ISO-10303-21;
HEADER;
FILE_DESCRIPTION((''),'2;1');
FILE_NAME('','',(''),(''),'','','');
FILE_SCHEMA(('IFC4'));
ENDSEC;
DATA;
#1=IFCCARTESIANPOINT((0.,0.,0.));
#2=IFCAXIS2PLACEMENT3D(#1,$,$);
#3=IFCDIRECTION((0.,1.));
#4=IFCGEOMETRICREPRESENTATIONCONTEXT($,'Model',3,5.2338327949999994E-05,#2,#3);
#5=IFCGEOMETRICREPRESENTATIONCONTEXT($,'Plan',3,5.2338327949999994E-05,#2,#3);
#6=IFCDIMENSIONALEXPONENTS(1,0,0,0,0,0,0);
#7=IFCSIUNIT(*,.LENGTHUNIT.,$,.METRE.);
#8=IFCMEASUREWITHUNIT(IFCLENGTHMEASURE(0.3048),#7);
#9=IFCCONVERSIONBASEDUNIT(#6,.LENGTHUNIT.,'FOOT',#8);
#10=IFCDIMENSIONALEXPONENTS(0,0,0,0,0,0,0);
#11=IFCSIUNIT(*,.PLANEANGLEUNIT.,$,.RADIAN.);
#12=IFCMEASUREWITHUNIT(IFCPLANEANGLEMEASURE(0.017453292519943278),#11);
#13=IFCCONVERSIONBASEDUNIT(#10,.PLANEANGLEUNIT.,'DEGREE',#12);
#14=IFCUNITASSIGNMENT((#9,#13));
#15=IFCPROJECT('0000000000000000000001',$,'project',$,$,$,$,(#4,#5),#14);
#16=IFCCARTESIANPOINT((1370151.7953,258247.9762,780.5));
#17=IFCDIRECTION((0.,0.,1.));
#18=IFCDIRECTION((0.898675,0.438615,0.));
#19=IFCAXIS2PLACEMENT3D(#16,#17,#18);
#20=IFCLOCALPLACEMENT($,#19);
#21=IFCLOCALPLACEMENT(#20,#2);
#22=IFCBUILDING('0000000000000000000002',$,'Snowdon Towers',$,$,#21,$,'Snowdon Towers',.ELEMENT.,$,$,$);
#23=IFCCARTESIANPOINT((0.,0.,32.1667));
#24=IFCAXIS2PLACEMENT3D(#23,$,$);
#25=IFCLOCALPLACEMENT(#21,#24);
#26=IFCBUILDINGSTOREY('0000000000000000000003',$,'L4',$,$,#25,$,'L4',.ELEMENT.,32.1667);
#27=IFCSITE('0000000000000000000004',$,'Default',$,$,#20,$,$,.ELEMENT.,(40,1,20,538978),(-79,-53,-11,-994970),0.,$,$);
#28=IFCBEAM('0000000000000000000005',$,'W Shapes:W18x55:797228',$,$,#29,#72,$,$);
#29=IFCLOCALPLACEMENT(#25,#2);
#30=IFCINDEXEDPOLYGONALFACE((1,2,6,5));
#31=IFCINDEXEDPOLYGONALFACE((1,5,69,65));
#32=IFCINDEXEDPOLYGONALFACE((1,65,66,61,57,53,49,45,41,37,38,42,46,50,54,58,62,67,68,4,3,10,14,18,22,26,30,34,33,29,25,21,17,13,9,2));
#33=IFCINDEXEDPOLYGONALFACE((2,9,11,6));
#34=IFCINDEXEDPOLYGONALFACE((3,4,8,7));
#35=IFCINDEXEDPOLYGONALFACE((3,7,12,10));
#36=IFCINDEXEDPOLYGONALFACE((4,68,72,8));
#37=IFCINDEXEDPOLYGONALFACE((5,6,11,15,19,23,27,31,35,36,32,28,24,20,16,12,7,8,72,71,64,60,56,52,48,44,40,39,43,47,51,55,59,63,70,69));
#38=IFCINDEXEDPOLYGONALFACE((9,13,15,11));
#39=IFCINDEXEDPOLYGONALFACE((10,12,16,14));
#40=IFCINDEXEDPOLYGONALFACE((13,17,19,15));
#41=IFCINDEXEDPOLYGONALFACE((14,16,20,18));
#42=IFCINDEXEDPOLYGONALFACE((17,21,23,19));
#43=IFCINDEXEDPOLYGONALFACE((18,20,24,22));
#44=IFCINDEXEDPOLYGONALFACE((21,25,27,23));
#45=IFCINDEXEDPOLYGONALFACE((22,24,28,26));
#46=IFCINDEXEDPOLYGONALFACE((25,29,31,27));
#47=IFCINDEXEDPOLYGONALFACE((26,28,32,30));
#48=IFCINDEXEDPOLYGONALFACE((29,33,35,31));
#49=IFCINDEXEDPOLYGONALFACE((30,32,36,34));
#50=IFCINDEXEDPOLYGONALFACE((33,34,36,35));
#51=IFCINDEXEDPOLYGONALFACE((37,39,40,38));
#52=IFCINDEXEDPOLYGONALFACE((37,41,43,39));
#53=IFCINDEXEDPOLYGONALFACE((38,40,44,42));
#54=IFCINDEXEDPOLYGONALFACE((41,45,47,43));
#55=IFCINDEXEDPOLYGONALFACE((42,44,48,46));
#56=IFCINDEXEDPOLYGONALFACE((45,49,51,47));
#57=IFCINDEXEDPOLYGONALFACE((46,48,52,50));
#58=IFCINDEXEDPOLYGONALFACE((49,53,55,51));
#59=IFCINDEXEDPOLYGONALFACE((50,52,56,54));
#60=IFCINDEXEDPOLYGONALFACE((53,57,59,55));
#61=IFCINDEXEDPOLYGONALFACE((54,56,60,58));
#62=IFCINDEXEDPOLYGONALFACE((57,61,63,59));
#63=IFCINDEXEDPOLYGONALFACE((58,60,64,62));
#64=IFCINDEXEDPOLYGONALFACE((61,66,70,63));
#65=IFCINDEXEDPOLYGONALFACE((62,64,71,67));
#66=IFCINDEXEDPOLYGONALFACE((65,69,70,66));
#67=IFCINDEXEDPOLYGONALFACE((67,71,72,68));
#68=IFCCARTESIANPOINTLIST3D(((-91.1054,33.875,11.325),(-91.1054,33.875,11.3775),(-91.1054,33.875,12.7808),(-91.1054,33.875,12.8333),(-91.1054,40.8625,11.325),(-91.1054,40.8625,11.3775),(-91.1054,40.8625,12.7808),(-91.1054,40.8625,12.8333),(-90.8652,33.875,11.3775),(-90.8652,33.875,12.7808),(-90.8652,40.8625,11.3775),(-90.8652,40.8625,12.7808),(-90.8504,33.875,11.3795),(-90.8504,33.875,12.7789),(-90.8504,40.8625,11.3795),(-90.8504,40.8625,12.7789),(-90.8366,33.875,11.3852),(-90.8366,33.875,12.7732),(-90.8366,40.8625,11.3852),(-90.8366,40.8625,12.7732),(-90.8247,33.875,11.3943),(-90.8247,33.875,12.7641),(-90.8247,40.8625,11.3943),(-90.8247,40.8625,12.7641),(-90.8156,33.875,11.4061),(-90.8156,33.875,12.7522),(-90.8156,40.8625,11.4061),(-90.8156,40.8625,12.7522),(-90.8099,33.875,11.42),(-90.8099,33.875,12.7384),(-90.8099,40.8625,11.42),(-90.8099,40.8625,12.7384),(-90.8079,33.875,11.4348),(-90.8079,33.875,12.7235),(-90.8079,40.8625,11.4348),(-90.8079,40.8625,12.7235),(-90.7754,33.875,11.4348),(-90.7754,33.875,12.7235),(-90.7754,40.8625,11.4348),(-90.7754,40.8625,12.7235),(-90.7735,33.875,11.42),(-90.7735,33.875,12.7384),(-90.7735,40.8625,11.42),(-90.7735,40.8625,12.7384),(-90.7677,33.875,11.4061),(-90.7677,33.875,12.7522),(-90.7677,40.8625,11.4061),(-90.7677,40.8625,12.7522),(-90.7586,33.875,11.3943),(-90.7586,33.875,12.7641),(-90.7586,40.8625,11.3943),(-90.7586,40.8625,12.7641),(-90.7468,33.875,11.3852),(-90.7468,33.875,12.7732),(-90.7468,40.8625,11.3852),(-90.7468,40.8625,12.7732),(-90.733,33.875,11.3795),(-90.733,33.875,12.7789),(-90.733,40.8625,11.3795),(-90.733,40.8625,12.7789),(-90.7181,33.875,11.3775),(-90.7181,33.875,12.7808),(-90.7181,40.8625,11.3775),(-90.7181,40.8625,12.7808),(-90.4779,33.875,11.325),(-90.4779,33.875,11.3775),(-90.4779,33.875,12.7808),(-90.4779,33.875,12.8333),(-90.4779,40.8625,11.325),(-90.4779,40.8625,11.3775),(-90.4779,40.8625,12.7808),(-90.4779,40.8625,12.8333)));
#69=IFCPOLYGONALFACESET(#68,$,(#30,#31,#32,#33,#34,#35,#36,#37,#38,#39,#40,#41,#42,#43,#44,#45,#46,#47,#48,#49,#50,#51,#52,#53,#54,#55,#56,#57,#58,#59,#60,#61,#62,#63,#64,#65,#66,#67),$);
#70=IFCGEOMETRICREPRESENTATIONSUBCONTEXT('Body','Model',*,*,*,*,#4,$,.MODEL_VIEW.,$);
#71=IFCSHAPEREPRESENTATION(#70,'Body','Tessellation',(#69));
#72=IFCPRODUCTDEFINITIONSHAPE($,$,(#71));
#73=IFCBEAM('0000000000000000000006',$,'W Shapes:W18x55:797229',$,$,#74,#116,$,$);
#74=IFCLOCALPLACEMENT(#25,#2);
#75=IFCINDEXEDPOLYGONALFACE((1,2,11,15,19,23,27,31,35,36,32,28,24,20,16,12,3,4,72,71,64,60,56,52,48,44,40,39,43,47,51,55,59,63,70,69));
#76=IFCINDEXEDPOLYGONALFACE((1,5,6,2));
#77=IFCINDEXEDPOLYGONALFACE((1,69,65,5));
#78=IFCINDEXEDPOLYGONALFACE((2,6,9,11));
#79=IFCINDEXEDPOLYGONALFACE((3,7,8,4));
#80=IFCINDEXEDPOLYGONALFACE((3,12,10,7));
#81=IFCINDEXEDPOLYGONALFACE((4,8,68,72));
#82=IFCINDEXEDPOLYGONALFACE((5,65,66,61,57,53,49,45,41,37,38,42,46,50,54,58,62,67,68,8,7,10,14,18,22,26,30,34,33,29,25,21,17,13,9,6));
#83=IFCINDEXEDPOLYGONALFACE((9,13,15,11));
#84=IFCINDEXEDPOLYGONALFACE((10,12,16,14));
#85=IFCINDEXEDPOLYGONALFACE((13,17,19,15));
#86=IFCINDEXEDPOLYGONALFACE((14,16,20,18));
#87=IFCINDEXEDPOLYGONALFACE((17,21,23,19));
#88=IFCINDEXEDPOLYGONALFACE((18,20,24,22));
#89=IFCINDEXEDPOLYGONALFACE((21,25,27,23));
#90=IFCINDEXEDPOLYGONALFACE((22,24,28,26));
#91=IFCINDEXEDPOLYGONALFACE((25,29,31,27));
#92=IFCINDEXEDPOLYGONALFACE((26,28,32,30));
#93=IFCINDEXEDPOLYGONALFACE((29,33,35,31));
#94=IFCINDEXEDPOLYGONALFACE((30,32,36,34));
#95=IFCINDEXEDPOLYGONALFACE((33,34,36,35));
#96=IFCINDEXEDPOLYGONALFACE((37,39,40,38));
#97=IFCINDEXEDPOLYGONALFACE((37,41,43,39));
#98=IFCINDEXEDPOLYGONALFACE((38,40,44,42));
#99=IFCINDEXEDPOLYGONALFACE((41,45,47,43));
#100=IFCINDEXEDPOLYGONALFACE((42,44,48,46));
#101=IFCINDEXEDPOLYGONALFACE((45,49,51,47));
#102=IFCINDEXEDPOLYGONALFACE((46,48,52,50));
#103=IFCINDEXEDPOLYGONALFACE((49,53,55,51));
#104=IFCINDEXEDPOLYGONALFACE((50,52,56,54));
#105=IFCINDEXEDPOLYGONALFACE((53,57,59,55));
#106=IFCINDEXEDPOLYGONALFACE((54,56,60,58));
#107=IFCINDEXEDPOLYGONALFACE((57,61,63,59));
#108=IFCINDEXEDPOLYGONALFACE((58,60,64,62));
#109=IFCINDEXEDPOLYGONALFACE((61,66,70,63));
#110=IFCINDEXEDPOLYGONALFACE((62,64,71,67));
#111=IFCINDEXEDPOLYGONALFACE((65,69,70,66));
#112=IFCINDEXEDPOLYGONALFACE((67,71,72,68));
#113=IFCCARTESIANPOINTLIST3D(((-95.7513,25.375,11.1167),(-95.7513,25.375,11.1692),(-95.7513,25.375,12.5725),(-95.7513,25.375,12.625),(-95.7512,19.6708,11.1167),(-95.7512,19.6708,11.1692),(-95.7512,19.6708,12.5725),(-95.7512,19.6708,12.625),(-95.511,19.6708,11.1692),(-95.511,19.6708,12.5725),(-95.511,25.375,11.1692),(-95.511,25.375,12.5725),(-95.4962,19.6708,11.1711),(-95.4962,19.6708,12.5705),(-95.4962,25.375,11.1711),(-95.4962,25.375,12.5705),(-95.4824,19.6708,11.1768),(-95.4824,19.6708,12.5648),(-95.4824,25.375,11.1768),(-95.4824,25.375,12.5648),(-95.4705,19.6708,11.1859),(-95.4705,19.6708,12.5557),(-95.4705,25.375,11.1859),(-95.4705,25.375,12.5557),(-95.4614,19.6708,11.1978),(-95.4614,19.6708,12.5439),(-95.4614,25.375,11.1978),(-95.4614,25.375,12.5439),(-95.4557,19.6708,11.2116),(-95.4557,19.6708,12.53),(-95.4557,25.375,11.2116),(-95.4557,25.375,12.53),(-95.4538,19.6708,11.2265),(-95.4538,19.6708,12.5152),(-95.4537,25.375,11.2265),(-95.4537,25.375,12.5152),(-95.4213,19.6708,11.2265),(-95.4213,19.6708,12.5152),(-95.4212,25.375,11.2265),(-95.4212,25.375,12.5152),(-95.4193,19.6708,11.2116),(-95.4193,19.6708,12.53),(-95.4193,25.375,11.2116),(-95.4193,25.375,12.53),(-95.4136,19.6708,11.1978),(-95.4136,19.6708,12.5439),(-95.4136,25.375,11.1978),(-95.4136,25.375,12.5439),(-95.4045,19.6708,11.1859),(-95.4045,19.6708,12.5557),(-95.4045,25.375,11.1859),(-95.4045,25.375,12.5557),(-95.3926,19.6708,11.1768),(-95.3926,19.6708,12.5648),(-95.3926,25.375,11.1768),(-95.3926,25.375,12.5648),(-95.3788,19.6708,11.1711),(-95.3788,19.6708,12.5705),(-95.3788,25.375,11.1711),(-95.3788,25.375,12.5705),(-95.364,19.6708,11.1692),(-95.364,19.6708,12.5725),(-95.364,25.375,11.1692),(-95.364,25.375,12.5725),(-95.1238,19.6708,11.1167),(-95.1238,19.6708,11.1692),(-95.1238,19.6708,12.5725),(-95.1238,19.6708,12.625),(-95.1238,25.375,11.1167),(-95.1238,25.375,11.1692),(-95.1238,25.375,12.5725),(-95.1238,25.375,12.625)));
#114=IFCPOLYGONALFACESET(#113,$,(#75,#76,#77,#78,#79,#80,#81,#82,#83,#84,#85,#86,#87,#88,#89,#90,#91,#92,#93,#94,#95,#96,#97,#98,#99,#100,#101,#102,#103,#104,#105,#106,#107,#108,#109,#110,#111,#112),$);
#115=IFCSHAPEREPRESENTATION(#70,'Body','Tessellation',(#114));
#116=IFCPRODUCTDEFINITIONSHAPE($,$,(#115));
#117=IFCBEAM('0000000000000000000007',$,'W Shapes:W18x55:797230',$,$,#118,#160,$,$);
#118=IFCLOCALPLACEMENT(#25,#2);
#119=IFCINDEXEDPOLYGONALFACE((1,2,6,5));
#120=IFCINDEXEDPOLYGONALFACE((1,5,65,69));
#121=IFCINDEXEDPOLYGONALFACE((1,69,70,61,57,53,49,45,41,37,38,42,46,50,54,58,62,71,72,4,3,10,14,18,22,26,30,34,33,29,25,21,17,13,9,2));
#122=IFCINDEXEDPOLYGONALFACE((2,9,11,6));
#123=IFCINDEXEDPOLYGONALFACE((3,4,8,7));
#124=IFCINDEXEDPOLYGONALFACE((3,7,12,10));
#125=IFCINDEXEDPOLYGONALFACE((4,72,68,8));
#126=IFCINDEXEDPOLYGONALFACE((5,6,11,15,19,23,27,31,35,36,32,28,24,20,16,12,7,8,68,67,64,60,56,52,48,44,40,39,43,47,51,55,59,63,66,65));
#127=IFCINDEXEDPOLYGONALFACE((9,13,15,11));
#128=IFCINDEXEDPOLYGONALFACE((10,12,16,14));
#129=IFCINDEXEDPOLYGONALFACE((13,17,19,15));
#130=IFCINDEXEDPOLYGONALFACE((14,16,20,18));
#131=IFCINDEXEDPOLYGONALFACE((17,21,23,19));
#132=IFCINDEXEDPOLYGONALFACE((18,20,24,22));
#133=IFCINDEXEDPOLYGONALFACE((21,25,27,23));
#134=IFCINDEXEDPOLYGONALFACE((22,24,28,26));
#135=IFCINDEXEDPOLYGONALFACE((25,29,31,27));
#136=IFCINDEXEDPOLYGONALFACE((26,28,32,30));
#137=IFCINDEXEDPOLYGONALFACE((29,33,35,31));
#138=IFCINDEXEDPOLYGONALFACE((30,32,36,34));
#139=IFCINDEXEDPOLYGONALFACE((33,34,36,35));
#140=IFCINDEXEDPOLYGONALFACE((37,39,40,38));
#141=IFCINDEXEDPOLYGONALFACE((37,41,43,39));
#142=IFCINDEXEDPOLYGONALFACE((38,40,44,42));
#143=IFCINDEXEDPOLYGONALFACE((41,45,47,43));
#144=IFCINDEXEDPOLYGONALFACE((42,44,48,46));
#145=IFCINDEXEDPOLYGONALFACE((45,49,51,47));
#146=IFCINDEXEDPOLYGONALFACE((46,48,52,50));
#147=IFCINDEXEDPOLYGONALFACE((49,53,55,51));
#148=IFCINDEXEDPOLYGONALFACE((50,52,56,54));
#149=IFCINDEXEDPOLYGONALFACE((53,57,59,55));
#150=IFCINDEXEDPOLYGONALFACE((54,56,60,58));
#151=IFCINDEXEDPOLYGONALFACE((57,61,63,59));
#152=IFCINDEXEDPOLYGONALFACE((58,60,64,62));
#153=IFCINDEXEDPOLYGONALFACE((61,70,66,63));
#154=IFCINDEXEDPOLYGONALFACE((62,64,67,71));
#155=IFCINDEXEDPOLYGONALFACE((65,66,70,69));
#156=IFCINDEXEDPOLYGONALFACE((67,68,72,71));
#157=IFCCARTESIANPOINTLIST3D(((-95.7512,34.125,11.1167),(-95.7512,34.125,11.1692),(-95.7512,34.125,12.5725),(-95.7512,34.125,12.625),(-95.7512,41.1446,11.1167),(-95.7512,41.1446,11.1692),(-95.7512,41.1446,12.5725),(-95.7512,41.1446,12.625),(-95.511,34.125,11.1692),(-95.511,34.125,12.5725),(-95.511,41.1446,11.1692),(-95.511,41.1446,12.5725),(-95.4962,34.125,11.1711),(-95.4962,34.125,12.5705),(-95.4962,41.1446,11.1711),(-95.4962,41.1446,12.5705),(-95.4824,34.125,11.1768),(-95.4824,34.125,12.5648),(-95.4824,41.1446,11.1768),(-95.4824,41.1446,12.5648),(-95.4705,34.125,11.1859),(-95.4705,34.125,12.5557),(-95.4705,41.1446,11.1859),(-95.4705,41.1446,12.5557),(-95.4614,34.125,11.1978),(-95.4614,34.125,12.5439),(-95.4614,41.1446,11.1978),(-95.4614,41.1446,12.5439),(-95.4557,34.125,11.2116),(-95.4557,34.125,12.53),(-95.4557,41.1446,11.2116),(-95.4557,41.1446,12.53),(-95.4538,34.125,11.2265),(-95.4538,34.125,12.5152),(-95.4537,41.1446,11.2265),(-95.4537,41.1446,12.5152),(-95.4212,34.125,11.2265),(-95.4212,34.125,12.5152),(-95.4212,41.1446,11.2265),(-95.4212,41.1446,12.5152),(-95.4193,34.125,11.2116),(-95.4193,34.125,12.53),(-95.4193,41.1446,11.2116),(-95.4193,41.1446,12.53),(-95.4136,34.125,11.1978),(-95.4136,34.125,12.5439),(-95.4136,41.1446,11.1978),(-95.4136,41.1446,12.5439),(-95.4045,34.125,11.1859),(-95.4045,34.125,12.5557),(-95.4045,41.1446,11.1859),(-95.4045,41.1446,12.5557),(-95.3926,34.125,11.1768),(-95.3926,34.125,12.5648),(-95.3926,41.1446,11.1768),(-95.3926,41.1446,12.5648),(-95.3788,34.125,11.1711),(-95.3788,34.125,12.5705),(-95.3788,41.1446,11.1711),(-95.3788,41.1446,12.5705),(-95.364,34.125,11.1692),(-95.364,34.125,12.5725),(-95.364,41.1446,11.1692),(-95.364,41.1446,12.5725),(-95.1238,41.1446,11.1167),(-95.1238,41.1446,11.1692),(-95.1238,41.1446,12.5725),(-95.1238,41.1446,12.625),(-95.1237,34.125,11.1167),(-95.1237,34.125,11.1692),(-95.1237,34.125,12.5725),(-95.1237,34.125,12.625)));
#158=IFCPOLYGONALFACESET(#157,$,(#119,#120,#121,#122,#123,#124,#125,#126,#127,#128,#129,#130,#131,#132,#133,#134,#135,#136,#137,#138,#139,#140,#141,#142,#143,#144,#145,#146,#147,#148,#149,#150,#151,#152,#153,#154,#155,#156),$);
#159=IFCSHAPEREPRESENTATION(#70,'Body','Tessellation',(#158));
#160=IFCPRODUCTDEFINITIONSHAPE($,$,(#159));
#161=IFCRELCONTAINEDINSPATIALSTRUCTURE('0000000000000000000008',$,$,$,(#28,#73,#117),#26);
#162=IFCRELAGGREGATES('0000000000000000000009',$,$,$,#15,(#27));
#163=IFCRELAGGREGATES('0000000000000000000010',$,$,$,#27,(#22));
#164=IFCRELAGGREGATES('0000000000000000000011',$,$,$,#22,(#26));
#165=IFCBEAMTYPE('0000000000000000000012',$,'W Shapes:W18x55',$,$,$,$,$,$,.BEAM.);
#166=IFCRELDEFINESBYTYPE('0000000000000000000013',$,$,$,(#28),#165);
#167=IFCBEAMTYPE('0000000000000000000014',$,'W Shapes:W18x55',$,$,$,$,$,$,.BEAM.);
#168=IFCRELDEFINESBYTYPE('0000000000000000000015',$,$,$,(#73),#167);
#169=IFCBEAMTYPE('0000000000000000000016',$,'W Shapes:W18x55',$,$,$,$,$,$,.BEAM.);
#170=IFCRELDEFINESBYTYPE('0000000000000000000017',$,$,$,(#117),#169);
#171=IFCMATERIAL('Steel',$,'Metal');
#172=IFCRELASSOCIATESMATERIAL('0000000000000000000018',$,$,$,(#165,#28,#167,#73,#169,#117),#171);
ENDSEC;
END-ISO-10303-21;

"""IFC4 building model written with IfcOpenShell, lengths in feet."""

from ifc_helpers import new_model, entity, si_unit, converted_unit, direction, frame, origin, place, context, subcontext, project, spatial, line, arc, indexed_curve, outline, extrude, source, transform, mapped, material, type_object, type_shapes, element, save


model = new_model("IFC4")

# Units and contexts
model_context = context("Model", 3, precision=5.2338327949999994e-05, world=origin(), true_north=direction((0.0, 1.0)))
plan_context = context("Plan", 3, precision=5.2338327949999994e-05, world=origin(), true_north=direction((0.0, 1.0)))
body_context = subcontext(model_context, "Body", "Model", "MODEL_VIEW")
ifc_project = project(units=[converted_unit("LENGTHUNIT", "FOOT", entity("IfcLengthMeasure", 0.3048), si_unit("LENGTHUNIT", "METRE"), dimensions=[1, 0, 0, 0, 0, 0, 0]), converted_unit("PLANEANGLEUNIT", "DEGREE", entity("IfcPlaneAngleMeasure", 0.017453292519943278), si_unit("PLANEANGLEUNIT", "RADIAN"), dimensions=[0, 0, 0, 0, 0, 0, 0])], contexts=[model_context, plan_context])

# Site, building, storey
site_placement = place(None, frame((1370151.7953, 258247.9762, 780.5), z_axis=(0.0, 0.0, 1.0), x_axis=(0.898675, 0.438615, 0.0)))
site = spatial("IfcSite", under=ifc_project, at=site_placement, Name="Default", CompositionType="ELEMENT", RefLatitude=(40, 1, 20, 538978), RefLongitude=(-79, -53, -11, -994970), RefElevation=0.0)
building_placement = place(site_placement, origin())
building = spatial("IfcBuilding", under=site, at=building_placement, Name="Snowdon Towers", LongName="Snowdon Towers", CompositionType="ELEMENT")
storey_placement = place(building_placement, frame((0.0, 0.0, 32.1667)))
storey = spatial("IfcBuildingStorey", under=building, at=storey_placement, Name="L4", LongName="L4", CompositionType="ELEMENT", Elevation=32.1667)

# Beams
ifc_material = material(Name="Steel", Category="Metal")
beam_type_1 = type_object("IfcBeamType", Name="W Shapes:W18x55", PredefinedType="BEAM", material=ifc_material)
shared_shape_1 = source(origin(), body_context, "Body", "SweptSolid", [
    extrude(outline(indexed_curve([(-0.3137, -0.7542), (0.3137, -0.7542), (0.3137, -0.7017), (0.0735, -0.7017), (0.033, -0.6849), (0.0162, -0.6444), (0.0162, 0.6444), (0.033, 0.6849), (0.0735, 0.7017), (0.3137, 0.7017), (0.3137, 0.7542), (-0.3137, 0.7542), (-0.3137, 0.7017), (-0.0735, 0.7017), (-0.033, 0.6849), (-0.0162, 0.6444), (-0.0162, -0.6444), (-0.033, -0.6849), (-0.0735, -0.7017), (-0.3137, -0.7017)], segments=[line(1, 2, 3, 4), arc(4, 5, 6), line(6, 7), arc(7, 8, 9), line(9, 10, 11, 12, 13, 14), arc(14, 15, 16), line(16, 17), arc(17, 18, 19), line(19, 20, 1)], self_intersect=False)), frame((-90.7917, 40.8625, 44.2458), z_axis=(0.0, -1.0, 0.0), x_axis=(-1.0, 0.0, 0.0)), (0.0, 0.0, 1.0), 6.9875),
])
type_shapes(beam_type_1, [shared_shape_1])
beam_1_placement = place(storey_placement, frame((0.0, 0.0, -32.1667)))
element("IfcBeam", 1, at=beam_1_placement, inside=storey, type_object=beam_type_1, material=ifc_material, Name="W Shapes:W18x55:797228", context=body_context, shape_type="MappedRepresentation", body=[
    mapped(shared_shape_1, transform((0.0, 0.0, 0.0), scale=1.0)),
])
beam_type_2 = type_object("IfcBeamType", Name="W Shapes:W18x55", PredefinedType="BEAM", material=ifc_material)
shared_shape_2 = source(origin(), body_context, "Body", "SweptSolid", [
    extrude(outline(indexed_curve([(-0.3138, -0.7542), (0.3137, -0.7542), (0.3137, -0.7017), (0.0735, -0.7017), (0.033, -0.6849), (0.0162, -0.6444), (0.0162, 0.6444), (0.033, 0.6849), (0.0735, 0.7017), (0.3137, 0.7017), (0.3137, 0.7542), (-0.3138, 0.7542), (-0.3138, 0.7017), (-0.0735, 0.7017), (-0.033, 0.6849), (-0.0163, 0.6444), (-0.0163, -0.6444), (-0.033, -0.6849), (-0.0735, -0.7017), (-0.3138, -0.7017)], segments=[line(1, 2, 3, 4), arc(4, 5, 6), line(6, 7), arc(7, 8, 9), line(9, 10, 11, 12, 13, 14), arc(14, 15, 16), line(16, 17), arc(17, 18, 19), line(19, 20, 1)], self_intersect=False)), frame((-95.4375, 19.6708, 44.0375), z_axis=(0.0, 1.0, 0.0), x_axis=(-1.0, 0.0, 0.0)), (0.0, 0.0, 1.0), 5.7042),
])
type_shapes(beam_type_2, [shared_shape_2])
beam_2_placement = place(storey_placement, frame((0.0, 0.0, -32.1667)))
element("IfcBeam", 2, at=beam_2_placement, inside=storey, type_object=beam_type_2, material=ifc_material, Name="W Shapes:W18x55:797229", context=body_context, shape_type="MappedRepresentation", body=[
    mapped(shared_shape_2, transform((0.0, 0.0, 0.0), scale=1.0)),
])
beam_type_3 = type_object("IfcBeamType", Name="W Shapes:W18x55", PredefinedType="BEAM", material=ifc_material)
shared_shape_3 = source(origin(), body_context, "Body", "SweptSolid", [
    extrude(outline(indexed_curve([(-0.3137, -0.7542), (0.3138, -0.7542), (0.3138, -0.7017), (0.0735, -0.7017), (0.033, -0.6849), (0.0163, -0.6444), (0.0163, 0.6444), (0.033, 0.6849), (0.0735, 0.7017), (0.3138, 0.7017), (0.3138, 0.7542), (-0.3137, 0.7542), (-0.3137, 0.7017), (-0.0735, 0.7017), (-0.033, 0.6849), (-0.0162, 0.6444), (-0.0162, -0.6444), (-0.033, -0.6849), (-0.0735, -0.7017), (-0.3137, -0.7017)], segments=[line(1, 2, 3, 4), arc(4, 5, 6), line(6, 7), arc(7, 8, 9), line(9, 10, 11, 12, 13, 14), arc(14, 15, 16), line(16, 17), arc(17, 18, 19), line(19, 20, 1)], self_intersect=False)), frame((-95.4375, 41.1446, 44.0375), z_axis=(0.0, -1.0, 0.0), x_axis=(-1.0, 0.0, 0.0)), (0.0, 0.0, 1.0), 7.0196),
])
type_shapes(beam_type_3, [shared_shape_3])
beam_3_placement = place(storey_placement, frame((0.0, 0.0, -32.1667)))
element("IfcBeam", 3, at=beam_3_placement, inside=storey, type_object=beam_type_3, material=ifc_material, Name="W Shapes:W18x55:797230", context=body_context, shape_type="MappedRepresentation", body=[
    mapped(shared_shape_3, transform((0.0, 0.0, 0.0), scale=1.0)),
])

save(model, "model.ifc")
